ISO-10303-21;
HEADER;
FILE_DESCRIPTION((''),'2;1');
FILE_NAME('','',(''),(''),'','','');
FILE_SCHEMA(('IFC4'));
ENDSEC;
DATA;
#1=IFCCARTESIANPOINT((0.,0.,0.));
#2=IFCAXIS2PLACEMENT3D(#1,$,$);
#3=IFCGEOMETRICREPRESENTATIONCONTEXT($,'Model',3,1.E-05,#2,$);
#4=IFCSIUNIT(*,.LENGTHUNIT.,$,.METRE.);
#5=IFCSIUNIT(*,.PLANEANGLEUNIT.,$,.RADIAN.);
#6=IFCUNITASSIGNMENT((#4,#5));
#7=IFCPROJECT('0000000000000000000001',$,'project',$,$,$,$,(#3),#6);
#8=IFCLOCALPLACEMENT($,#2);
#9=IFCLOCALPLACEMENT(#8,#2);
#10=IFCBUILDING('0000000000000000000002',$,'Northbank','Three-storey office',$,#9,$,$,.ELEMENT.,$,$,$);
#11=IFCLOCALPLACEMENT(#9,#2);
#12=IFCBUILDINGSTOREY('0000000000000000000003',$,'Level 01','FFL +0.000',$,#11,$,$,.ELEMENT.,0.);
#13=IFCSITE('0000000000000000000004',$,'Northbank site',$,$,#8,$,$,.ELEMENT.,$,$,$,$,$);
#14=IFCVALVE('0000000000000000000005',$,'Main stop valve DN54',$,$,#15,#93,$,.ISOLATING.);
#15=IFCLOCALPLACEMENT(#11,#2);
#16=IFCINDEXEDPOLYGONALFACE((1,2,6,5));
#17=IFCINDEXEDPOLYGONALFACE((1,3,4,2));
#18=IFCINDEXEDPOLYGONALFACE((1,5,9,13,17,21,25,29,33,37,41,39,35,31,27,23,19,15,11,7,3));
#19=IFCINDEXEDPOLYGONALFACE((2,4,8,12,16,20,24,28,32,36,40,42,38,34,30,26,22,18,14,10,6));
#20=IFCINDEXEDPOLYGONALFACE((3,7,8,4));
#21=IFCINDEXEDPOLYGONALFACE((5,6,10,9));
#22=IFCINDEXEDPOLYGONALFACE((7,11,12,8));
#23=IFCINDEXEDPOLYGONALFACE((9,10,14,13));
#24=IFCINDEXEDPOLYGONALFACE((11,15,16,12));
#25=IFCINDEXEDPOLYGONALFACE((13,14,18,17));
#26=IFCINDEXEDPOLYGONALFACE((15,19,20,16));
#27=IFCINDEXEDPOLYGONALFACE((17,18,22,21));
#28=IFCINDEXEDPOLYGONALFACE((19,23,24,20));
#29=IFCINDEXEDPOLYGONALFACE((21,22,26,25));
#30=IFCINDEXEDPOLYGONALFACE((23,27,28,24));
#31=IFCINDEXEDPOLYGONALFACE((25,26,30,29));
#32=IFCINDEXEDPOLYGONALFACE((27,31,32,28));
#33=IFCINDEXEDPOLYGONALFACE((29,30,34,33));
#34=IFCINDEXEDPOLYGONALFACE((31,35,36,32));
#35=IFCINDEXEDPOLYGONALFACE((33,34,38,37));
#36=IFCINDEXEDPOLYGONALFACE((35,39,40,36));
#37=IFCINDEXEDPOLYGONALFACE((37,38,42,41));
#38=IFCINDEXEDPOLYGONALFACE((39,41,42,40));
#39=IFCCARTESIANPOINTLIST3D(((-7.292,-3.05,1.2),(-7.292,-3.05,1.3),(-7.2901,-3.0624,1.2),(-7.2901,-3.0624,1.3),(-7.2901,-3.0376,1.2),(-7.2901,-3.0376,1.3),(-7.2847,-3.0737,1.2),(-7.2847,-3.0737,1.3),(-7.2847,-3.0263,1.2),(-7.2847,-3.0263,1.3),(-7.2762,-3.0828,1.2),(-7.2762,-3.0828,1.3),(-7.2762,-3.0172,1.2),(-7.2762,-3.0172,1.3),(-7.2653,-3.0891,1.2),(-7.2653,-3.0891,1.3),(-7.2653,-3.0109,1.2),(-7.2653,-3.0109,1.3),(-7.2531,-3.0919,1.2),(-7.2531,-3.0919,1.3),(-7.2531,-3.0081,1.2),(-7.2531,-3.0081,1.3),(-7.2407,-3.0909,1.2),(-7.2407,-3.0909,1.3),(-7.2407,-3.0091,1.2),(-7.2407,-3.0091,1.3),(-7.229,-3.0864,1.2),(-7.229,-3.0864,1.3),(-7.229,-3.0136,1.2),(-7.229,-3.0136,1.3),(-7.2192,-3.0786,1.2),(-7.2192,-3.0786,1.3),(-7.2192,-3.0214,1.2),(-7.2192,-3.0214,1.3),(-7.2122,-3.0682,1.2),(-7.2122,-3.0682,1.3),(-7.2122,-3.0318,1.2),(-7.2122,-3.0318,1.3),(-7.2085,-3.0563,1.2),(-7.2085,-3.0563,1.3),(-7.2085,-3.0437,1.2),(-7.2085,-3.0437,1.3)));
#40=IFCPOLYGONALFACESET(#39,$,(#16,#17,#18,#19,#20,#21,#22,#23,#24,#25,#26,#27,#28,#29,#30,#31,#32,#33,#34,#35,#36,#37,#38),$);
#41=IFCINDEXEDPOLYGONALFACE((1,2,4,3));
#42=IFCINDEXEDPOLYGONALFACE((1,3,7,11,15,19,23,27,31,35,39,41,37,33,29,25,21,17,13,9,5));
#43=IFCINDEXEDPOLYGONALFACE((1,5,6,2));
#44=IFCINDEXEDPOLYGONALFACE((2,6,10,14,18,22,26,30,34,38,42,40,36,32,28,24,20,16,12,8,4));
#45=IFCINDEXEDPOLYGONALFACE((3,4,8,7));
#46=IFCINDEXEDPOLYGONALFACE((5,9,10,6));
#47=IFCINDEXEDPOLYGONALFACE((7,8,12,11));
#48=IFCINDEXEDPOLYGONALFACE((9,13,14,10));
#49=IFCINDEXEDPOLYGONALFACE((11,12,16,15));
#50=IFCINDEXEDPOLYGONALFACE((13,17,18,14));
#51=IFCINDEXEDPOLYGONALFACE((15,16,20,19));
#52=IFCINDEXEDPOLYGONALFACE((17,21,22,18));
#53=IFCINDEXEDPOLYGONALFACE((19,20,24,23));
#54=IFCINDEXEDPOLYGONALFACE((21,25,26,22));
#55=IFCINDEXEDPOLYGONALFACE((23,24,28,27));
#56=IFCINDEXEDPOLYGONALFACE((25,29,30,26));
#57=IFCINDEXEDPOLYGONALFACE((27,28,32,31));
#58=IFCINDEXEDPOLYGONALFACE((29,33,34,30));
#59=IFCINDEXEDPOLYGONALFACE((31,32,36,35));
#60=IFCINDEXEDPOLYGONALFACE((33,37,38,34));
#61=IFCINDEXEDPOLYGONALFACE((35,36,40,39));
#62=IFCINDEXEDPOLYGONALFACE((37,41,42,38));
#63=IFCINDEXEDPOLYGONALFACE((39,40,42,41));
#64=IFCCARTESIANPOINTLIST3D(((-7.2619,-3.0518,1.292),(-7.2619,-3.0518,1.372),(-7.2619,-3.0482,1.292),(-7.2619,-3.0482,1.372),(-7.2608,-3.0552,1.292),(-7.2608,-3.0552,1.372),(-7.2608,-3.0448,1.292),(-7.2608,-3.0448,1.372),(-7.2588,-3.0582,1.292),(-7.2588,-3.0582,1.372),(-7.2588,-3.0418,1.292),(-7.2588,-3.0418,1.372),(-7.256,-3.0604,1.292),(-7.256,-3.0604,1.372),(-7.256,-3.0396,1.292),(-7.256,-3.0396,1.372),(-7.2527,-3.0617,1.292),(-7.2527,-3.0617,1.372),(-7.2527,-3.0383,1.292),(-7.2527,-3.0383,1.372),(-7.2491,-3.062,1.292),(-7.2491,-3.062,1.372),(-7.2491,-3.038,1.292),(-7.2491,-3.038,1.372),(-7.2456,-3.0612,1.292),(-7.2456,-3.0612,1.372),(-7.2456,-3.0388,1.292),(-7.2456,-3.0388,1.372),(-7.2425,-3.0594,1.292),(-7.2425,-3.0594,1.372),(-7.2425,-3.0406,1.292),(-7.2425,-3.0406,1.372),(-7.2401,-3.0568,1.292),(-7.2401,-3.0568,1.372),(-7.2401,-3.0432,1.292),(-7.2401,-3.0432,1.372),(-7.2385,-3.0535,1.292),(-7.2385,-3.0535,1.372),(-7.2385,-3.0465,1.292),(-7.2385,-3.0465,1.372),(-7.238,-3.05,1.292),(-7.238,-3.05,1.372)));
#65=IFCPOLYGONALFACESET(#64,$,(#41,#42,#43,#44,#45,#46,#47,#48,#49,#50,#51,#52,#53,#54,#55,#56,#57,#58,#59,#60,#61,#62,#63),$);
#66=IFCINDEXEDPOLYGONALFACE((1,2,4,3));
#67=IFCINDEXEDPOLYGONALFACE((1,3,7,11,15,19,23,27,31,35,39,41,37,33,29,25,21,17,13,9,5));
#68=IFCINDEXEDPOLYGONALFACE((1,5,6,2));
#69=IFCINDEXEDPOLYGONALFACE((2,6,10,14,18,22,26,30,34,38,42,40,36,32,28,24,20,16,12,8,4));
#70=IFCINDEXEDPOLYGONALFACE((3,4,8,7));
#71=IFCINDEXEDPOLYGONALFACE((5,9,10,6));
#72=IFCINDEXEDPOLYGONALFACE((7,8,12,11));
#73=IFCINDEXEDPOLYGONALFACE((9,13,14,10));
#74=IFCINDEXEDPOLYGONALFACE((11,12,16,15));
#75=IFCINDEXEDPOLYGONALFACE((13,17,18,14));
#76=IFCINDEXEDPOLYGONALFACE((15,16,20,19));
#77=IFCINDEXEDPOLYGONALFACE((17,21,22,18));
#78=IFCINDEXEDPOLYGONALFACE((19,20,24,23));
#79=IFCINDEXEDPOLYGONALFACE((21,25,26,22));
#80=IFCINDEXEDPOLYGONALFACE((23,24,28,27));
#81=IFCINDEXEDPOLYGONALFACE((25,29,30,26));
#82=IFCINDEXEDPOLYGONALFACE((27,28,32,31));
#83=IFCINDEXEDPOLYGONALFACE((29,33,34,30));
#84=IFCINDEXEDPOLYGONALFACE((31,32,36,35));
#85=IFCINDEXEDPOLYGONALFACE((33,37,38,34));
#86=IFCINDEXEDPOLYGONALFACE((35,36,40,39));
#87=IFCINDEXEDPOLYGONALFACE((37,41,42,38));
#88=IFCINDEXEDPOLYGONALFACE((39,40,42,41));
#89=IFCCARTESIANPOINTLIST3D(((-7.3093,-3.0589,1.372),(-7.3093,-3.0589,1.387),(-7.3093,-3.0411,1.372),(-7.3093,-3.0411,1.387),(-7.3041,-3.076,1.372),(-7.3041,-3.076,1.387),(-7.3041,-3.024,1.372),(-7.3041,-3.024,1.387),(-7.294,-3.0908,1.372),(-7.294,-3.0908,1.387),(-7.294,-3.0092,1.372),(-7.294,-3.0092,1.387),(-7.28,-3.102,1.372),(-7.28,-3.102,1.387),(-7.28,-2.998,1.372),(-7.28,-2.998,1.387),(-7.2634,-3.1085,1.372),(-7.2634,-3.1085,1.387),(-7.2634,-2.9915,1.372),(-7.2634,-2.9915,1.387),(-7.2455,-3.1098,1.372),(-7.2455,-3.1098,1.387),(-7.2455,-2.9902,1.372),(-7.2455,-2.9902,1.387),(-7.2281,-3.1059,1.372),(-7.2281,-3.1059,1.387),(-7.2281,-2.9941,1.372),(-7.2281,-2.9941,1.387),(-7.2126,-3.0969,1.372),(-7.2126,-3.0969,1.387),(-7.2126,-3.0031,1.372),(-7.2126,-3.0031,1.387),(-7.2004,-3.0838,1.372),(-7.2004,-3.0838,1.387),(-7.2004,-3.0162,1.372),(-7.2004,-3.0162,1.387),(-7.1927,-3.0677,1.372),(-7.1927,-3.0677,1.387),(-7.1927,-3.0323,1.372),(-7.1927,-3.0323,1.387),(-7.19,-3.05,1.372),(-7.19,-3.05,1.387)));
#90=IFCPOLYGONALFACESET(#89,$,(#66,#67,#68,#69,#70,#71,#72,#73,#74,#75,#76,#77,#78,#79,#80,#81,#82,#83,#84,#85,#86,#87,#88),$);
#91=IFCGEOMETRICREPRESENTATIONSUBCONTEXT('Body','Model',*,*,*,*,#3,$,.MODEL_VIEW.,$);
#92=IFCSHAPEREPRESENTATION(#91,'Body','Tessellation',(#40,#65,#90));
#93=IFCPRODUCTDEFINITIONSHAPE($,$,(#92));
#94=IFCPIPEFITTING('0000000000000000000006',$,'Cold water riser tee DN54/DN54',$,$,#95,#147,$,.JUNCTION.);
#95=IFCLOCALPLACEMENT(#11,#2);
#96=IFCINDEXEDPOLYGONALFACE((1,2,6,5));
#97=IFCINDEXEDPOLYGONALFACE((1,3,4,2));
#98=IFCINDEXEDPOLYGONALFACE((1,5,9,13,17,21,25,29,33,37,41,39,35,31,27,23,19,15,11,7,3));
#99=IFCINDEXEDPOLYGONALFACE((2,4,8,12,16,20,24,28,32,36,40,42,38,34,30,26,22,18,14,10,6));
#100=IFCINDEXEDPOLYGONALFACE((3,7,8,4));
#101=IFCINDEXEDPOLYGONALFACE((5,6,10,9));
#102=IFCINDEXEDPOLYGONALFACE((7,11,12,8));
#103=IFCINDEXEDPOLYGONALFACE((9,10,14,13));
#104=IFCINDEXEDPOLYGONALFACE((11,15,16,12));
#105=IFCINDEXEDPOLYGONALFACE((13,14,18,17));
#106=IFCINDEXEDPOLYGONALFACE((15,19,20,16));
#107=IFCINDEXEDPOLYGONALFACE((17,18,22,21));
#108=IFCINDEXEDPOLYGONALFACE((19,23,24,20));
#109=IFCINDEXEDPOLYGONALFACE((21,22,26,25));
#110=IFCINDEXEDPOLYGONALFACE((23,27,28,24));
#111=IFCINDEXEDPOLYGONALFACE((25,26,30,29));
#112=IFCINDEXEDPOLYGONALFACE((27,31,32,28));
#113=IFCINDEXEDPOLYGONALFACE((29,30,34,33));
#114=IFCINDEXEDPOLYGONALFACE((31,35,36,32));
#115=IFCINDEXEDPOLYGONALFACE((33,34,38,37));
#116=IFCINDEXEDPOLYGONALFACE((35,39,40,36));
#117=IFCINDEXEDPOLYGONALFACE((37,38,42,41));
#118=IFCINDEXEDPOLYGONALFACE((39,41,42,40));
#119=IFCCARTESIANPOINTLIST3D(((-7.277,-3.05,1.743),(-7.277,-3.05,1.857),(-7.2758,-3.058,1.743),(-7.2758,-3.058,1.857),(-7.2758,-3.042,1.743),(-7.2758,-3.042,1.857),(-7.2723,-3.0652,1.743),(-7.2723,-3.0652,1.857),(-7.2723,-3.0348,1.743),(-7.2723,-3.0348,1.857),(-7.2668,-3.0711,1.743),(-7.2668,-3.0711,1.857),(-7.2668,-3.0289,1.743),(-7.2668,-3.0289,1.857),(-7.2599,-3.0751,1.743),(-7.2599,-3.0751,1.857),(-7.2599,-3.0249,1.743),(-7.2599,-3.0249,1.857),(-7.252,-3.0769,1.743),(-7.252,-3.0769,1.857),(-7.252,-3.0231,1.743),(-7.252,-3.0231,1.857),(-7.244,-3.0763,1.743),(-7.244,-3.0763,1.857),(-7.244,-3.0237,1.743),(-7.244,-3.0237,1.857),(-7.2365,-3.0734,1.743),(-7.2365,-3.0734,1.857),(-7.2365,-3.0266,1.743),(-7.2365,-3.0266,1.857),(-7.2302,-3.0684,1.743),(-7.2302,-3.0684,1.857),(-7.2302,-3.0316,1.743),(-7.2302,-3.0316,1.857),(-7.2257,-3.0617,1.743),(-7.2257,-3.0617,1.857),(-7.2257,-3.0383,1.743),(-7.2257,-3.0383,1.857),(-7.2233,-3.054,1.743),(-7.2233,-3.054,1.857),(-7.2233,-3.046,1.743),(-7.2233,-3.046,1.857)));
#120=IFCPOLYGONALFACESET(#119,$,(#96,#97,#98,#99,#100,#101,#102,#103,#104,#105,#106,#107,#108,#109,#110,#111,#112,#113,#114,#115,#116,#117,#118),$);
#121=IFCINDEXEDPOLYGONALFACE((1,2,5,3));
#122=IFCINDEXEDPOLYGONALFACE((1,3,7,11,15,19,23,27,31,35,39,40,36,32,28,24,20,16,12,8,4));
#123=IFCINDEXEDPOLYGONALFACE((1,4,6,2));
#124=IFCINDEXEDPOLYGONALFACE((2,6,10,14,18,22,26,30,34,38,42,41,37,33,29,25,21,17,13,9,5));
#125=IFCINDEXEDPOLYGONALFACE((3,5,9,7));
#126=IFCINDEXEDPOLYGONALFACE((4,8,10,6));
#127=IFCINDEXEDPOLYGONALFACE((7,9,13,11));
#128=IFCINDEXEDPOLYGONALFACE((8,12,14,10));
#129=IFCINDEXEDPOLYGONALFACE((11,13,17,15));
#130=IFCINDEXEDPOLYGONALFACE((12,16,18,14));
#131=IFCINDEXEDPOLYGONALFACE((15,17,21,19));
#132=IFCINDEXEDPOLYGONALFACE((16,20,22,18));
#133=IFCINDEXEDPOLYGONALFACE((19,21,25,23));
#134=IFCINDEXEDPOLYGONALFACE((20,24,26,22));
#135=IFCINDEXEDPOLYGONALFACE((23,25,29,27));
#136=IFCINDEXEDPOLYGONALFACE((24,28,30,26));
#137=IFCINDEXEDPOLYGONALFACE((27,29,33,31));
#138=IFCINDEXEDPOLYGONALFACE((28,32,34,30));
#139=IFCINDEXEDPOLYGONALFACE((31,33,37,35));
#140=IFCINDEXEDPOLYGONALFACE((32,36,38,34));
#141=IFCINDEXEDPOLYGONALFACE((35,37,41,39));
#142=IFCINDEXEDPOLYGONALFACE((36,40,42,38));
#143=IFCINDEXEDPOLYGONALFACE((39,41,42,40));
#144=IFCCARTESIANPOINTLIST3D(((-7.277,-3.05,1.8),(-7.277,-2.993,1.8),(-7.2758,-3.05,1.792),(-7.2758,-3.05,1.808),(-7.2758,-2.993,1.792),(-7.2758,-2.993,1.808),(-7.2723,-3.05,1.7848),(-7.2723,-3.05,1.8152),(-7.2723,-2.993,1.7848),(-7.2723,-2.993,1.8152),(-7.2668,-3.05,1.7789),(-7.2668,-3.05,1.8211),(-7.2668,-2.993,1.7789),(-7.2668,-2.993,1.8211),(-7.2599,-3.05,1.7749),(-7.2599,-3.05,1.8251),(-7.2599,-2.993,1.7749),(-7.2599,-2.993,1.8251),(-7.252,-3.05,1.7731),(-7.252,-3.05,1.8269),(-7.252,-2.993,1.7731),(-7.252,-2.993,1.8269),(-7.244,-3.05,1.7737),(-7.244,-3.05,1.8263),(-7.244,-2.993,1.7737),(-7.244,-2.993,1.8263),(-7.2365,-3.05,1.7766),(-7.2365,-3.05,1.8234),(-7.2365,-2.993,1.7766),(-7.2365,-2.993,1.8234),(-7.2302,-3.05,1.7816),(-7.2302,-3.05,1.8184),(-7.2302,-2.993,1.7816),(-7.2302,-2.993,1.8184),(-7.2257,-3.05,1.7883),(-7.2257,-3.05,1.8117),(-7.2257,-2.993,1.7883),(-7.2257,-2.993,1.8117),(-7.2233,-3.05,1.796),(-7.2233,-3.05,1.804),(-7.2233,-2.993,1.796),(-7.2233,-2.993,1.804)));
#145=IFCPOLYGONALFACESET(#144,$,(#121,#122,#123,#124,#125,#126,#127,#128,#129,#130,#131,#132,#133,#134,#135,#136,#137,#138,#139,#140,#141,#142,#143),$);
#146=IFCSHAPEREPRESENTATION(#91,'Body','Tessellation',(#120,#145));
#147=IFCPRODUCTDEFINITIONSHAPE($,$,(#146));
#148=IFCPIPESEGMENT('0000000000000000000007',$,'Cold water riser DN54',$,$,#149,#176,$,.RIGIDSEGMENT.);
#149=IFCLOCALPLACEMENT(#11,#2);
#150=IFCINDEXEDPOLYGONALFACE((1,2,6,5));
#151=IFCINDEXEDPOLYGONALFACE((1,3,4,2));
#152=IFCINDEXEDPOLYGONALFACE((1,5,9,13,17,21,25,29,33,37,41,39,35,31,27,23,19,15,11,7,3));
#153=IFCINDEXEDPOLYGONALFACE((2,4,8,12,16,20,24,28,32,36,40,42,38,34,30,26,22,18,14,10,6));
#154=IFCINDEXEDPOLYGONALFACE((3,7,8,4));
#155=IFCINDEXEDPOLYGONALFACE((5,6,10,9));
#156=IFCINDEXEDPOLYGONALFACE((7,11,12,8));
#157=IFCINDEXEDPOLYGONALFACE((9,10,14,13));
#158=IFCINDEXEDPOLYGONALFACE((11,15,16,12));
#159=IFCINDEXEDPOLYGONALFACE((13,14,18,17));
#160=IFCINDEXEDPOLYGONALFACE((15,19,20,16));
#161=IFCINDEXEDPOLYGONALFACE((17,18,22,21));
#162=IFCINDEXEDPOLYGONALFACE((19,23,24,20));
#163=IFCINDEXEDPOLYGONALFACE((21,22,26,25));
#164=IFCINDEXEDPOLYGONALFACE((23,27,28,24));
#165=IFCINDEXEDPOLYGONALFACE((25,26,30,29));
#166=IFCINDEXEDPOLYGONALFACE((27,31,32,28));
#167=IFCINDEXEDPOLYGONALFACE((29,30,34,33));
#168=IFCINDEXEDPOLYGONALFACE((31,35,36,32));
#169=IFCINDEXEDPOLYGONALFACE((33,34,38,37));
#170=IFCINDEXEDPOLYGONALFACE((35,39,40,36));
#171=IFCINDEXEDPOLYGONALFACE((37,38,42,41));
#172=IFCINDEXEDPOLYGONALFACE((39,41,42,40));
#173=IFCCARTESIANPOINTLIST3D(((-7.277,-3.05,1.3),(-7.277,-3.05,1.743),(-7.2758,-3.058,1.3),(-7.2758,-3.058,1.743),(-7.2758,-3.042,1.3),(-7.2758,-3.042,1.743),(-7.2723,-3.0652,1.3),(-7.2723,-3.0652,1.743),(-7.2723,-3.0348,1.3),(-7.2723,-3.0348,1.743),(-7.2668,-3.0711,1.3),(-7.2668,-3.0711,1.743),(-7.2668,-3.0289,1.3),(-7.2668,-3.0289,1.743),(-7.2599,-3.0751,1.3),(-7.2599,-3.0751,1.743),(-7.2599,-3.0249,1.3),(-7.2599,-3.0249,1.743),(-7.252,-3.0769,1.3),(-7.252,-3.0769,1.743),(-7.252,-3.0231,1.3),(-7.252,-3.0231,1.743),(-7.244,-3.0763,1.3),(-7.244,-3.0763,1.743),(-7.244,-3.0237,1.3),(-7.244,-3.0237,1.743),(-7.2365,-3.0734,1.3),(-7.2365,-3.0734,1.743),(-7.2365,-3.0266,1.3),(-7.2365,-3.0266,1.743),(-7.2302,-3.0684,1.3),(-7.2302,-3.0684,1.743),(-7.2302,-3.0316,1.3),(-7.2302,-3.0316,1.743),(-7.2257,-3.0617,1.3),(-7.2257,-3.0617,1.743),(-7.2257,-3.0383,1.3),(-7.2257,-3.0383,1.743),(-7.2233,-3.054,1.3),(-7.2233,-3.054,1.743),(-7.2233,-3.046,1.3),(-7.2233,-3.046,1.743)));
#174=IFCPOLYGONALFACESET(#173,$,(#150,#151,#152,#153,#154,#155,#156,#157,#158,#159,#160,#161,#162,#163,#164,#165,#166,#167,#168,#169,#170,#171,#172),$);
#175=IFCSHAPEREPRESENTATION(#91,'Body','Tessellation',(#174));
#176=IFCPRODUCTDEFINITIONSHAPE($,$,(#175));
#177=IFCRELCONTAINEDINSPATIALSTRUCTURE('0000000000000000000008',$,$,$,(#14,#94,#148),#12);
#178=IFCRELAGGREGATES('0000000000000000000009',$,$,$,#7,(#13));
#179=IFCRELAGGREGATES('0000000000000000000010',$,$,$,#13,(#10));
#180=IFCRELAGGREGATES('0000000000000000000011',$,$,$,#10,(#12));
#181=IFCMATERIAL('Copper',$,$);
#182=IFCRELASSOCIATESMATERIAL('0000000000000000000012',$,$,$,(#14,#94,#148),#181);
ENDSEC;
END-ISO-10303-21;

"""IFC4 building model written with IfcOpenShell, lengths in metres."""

from ifc_helpers import new_model, si_unit, frame, origin, place, context, subcontext, project, spatial, circle, extrude, material, element, save


model = new_model("IFC4")

# Units and contexts
model_context = context("Model", 3, precision=1e-05, world=origin())
body_context = subcontext(model_context, "Body", "Model", "MODEL_VIEW")
ifc_project = project(units=[si_unit("LENGTHUNIT", "METRE"), si_unit("PLANEANGLEUNIT", "RADIAN")], contexts=[model_context])

# Site, building, storey
site_placement = place(None, origin())
site = spatial("IfcSite", under=ifc_project, at=site_placement, Name="Northbank site", CompositionType="ELEMENT")
building_placement = place(site_placement, origin())
building = spatial("IfcBuilding", under=site, at=building_placement, Name="Northbank", Description="Three-storey office", CompositionType="ELEMENT")
storey_placement = place(building_placement, origin())
storey = spatial("IfcBuildingStorey", under=building, at=storey_placement, Name="Level 01", Description="FFL +0.000", CompositionType="ELEMENT", Elevation=0.0)

# Shared definitions
ifc_material_1 = material(Name="Copper")

# Valve
valve_placement = place(storey_placement, origin())
element("IfcValve", 1, at=valve_placement, inside=storey, material=ifc_material_1, Name="Main stop valve DN54", PredefinedType="ISOLATING", context=body_context, shape_type="SweptSolid", body=[
    extrude(circle(Radius=0.042), frame((-7.25, -3.05, 1.2), z_axis=(0.0, 0.0, 1.0), x_axis=(-1.0, 0.0, 0.0)), (0.0, 0.0, 1.0), 0.1),
    extrude(circle(Radius=0.012), frame((-7.25, -3.05, 1.292), z_axis=(0.0, 0.0, 1.0), x_axis=(1.0, 0.0, 0.0)), (0.0, 0.0, 1.0), 0.08),
    extrude(circle(Radius=0.06), frame((-7.25, -3.05, 1.372), z_axis=(0.0, 0.0, 1.0), x_axis=(1.0, 0.0, 0.0)), (0.0, 0.0, 1.0), 0.015),
])

# Pipe fitting
pipe_fitting_placement = place(storey_placement, origin())
element("IfcPipeFitting", 2, at=pipe_fitting_placement, inside=storey, material=ifc_material_1, Name="Cold water riser tee DN54/DN54", PredefinedType="JUNCTION", context=body_context, shape_type="SweptSolid", body=[
    extrude(circle(Radius=0.027), frame((-7.25, -3.05, 1.743), z_axis=(0.0, 0.0, 1.0), x_axis=(-1.0, 0.0, 0.0)), (0.0, 0.0, 1.0), 0.114),
    extrude(circle(Radius=0.027), frame((-7.25, -3.05, 1.8), z_axis=(0.0, 1.0, 0.0), x_axis=(-1.0, 0.0, 0.0)), (0.0, 0.0, 1.0), 0.057),
])

# Pipe segment
pipe_segment_1_placement = place(storey_placement, origin())
element("IfcPipeSegment", 3, at=pipe_segment_1_placement, inside=storey, material=ifc_material_1, Name="Cold water riser DN54", PredefinedType="RIGIDSEGMENT", context=body_context, shape_type="SweptSolid", body=[
    extrude(circle(Radius=0.027), frame((-7.25, -3.05, 1.3), z_axis=(0.0, 0.0, 1.0), x_axis=(-1.0, 0.0, 0.0)), (0.0, 0.0, 1.0), 0.443),
])

save(model, "model.ifc")
